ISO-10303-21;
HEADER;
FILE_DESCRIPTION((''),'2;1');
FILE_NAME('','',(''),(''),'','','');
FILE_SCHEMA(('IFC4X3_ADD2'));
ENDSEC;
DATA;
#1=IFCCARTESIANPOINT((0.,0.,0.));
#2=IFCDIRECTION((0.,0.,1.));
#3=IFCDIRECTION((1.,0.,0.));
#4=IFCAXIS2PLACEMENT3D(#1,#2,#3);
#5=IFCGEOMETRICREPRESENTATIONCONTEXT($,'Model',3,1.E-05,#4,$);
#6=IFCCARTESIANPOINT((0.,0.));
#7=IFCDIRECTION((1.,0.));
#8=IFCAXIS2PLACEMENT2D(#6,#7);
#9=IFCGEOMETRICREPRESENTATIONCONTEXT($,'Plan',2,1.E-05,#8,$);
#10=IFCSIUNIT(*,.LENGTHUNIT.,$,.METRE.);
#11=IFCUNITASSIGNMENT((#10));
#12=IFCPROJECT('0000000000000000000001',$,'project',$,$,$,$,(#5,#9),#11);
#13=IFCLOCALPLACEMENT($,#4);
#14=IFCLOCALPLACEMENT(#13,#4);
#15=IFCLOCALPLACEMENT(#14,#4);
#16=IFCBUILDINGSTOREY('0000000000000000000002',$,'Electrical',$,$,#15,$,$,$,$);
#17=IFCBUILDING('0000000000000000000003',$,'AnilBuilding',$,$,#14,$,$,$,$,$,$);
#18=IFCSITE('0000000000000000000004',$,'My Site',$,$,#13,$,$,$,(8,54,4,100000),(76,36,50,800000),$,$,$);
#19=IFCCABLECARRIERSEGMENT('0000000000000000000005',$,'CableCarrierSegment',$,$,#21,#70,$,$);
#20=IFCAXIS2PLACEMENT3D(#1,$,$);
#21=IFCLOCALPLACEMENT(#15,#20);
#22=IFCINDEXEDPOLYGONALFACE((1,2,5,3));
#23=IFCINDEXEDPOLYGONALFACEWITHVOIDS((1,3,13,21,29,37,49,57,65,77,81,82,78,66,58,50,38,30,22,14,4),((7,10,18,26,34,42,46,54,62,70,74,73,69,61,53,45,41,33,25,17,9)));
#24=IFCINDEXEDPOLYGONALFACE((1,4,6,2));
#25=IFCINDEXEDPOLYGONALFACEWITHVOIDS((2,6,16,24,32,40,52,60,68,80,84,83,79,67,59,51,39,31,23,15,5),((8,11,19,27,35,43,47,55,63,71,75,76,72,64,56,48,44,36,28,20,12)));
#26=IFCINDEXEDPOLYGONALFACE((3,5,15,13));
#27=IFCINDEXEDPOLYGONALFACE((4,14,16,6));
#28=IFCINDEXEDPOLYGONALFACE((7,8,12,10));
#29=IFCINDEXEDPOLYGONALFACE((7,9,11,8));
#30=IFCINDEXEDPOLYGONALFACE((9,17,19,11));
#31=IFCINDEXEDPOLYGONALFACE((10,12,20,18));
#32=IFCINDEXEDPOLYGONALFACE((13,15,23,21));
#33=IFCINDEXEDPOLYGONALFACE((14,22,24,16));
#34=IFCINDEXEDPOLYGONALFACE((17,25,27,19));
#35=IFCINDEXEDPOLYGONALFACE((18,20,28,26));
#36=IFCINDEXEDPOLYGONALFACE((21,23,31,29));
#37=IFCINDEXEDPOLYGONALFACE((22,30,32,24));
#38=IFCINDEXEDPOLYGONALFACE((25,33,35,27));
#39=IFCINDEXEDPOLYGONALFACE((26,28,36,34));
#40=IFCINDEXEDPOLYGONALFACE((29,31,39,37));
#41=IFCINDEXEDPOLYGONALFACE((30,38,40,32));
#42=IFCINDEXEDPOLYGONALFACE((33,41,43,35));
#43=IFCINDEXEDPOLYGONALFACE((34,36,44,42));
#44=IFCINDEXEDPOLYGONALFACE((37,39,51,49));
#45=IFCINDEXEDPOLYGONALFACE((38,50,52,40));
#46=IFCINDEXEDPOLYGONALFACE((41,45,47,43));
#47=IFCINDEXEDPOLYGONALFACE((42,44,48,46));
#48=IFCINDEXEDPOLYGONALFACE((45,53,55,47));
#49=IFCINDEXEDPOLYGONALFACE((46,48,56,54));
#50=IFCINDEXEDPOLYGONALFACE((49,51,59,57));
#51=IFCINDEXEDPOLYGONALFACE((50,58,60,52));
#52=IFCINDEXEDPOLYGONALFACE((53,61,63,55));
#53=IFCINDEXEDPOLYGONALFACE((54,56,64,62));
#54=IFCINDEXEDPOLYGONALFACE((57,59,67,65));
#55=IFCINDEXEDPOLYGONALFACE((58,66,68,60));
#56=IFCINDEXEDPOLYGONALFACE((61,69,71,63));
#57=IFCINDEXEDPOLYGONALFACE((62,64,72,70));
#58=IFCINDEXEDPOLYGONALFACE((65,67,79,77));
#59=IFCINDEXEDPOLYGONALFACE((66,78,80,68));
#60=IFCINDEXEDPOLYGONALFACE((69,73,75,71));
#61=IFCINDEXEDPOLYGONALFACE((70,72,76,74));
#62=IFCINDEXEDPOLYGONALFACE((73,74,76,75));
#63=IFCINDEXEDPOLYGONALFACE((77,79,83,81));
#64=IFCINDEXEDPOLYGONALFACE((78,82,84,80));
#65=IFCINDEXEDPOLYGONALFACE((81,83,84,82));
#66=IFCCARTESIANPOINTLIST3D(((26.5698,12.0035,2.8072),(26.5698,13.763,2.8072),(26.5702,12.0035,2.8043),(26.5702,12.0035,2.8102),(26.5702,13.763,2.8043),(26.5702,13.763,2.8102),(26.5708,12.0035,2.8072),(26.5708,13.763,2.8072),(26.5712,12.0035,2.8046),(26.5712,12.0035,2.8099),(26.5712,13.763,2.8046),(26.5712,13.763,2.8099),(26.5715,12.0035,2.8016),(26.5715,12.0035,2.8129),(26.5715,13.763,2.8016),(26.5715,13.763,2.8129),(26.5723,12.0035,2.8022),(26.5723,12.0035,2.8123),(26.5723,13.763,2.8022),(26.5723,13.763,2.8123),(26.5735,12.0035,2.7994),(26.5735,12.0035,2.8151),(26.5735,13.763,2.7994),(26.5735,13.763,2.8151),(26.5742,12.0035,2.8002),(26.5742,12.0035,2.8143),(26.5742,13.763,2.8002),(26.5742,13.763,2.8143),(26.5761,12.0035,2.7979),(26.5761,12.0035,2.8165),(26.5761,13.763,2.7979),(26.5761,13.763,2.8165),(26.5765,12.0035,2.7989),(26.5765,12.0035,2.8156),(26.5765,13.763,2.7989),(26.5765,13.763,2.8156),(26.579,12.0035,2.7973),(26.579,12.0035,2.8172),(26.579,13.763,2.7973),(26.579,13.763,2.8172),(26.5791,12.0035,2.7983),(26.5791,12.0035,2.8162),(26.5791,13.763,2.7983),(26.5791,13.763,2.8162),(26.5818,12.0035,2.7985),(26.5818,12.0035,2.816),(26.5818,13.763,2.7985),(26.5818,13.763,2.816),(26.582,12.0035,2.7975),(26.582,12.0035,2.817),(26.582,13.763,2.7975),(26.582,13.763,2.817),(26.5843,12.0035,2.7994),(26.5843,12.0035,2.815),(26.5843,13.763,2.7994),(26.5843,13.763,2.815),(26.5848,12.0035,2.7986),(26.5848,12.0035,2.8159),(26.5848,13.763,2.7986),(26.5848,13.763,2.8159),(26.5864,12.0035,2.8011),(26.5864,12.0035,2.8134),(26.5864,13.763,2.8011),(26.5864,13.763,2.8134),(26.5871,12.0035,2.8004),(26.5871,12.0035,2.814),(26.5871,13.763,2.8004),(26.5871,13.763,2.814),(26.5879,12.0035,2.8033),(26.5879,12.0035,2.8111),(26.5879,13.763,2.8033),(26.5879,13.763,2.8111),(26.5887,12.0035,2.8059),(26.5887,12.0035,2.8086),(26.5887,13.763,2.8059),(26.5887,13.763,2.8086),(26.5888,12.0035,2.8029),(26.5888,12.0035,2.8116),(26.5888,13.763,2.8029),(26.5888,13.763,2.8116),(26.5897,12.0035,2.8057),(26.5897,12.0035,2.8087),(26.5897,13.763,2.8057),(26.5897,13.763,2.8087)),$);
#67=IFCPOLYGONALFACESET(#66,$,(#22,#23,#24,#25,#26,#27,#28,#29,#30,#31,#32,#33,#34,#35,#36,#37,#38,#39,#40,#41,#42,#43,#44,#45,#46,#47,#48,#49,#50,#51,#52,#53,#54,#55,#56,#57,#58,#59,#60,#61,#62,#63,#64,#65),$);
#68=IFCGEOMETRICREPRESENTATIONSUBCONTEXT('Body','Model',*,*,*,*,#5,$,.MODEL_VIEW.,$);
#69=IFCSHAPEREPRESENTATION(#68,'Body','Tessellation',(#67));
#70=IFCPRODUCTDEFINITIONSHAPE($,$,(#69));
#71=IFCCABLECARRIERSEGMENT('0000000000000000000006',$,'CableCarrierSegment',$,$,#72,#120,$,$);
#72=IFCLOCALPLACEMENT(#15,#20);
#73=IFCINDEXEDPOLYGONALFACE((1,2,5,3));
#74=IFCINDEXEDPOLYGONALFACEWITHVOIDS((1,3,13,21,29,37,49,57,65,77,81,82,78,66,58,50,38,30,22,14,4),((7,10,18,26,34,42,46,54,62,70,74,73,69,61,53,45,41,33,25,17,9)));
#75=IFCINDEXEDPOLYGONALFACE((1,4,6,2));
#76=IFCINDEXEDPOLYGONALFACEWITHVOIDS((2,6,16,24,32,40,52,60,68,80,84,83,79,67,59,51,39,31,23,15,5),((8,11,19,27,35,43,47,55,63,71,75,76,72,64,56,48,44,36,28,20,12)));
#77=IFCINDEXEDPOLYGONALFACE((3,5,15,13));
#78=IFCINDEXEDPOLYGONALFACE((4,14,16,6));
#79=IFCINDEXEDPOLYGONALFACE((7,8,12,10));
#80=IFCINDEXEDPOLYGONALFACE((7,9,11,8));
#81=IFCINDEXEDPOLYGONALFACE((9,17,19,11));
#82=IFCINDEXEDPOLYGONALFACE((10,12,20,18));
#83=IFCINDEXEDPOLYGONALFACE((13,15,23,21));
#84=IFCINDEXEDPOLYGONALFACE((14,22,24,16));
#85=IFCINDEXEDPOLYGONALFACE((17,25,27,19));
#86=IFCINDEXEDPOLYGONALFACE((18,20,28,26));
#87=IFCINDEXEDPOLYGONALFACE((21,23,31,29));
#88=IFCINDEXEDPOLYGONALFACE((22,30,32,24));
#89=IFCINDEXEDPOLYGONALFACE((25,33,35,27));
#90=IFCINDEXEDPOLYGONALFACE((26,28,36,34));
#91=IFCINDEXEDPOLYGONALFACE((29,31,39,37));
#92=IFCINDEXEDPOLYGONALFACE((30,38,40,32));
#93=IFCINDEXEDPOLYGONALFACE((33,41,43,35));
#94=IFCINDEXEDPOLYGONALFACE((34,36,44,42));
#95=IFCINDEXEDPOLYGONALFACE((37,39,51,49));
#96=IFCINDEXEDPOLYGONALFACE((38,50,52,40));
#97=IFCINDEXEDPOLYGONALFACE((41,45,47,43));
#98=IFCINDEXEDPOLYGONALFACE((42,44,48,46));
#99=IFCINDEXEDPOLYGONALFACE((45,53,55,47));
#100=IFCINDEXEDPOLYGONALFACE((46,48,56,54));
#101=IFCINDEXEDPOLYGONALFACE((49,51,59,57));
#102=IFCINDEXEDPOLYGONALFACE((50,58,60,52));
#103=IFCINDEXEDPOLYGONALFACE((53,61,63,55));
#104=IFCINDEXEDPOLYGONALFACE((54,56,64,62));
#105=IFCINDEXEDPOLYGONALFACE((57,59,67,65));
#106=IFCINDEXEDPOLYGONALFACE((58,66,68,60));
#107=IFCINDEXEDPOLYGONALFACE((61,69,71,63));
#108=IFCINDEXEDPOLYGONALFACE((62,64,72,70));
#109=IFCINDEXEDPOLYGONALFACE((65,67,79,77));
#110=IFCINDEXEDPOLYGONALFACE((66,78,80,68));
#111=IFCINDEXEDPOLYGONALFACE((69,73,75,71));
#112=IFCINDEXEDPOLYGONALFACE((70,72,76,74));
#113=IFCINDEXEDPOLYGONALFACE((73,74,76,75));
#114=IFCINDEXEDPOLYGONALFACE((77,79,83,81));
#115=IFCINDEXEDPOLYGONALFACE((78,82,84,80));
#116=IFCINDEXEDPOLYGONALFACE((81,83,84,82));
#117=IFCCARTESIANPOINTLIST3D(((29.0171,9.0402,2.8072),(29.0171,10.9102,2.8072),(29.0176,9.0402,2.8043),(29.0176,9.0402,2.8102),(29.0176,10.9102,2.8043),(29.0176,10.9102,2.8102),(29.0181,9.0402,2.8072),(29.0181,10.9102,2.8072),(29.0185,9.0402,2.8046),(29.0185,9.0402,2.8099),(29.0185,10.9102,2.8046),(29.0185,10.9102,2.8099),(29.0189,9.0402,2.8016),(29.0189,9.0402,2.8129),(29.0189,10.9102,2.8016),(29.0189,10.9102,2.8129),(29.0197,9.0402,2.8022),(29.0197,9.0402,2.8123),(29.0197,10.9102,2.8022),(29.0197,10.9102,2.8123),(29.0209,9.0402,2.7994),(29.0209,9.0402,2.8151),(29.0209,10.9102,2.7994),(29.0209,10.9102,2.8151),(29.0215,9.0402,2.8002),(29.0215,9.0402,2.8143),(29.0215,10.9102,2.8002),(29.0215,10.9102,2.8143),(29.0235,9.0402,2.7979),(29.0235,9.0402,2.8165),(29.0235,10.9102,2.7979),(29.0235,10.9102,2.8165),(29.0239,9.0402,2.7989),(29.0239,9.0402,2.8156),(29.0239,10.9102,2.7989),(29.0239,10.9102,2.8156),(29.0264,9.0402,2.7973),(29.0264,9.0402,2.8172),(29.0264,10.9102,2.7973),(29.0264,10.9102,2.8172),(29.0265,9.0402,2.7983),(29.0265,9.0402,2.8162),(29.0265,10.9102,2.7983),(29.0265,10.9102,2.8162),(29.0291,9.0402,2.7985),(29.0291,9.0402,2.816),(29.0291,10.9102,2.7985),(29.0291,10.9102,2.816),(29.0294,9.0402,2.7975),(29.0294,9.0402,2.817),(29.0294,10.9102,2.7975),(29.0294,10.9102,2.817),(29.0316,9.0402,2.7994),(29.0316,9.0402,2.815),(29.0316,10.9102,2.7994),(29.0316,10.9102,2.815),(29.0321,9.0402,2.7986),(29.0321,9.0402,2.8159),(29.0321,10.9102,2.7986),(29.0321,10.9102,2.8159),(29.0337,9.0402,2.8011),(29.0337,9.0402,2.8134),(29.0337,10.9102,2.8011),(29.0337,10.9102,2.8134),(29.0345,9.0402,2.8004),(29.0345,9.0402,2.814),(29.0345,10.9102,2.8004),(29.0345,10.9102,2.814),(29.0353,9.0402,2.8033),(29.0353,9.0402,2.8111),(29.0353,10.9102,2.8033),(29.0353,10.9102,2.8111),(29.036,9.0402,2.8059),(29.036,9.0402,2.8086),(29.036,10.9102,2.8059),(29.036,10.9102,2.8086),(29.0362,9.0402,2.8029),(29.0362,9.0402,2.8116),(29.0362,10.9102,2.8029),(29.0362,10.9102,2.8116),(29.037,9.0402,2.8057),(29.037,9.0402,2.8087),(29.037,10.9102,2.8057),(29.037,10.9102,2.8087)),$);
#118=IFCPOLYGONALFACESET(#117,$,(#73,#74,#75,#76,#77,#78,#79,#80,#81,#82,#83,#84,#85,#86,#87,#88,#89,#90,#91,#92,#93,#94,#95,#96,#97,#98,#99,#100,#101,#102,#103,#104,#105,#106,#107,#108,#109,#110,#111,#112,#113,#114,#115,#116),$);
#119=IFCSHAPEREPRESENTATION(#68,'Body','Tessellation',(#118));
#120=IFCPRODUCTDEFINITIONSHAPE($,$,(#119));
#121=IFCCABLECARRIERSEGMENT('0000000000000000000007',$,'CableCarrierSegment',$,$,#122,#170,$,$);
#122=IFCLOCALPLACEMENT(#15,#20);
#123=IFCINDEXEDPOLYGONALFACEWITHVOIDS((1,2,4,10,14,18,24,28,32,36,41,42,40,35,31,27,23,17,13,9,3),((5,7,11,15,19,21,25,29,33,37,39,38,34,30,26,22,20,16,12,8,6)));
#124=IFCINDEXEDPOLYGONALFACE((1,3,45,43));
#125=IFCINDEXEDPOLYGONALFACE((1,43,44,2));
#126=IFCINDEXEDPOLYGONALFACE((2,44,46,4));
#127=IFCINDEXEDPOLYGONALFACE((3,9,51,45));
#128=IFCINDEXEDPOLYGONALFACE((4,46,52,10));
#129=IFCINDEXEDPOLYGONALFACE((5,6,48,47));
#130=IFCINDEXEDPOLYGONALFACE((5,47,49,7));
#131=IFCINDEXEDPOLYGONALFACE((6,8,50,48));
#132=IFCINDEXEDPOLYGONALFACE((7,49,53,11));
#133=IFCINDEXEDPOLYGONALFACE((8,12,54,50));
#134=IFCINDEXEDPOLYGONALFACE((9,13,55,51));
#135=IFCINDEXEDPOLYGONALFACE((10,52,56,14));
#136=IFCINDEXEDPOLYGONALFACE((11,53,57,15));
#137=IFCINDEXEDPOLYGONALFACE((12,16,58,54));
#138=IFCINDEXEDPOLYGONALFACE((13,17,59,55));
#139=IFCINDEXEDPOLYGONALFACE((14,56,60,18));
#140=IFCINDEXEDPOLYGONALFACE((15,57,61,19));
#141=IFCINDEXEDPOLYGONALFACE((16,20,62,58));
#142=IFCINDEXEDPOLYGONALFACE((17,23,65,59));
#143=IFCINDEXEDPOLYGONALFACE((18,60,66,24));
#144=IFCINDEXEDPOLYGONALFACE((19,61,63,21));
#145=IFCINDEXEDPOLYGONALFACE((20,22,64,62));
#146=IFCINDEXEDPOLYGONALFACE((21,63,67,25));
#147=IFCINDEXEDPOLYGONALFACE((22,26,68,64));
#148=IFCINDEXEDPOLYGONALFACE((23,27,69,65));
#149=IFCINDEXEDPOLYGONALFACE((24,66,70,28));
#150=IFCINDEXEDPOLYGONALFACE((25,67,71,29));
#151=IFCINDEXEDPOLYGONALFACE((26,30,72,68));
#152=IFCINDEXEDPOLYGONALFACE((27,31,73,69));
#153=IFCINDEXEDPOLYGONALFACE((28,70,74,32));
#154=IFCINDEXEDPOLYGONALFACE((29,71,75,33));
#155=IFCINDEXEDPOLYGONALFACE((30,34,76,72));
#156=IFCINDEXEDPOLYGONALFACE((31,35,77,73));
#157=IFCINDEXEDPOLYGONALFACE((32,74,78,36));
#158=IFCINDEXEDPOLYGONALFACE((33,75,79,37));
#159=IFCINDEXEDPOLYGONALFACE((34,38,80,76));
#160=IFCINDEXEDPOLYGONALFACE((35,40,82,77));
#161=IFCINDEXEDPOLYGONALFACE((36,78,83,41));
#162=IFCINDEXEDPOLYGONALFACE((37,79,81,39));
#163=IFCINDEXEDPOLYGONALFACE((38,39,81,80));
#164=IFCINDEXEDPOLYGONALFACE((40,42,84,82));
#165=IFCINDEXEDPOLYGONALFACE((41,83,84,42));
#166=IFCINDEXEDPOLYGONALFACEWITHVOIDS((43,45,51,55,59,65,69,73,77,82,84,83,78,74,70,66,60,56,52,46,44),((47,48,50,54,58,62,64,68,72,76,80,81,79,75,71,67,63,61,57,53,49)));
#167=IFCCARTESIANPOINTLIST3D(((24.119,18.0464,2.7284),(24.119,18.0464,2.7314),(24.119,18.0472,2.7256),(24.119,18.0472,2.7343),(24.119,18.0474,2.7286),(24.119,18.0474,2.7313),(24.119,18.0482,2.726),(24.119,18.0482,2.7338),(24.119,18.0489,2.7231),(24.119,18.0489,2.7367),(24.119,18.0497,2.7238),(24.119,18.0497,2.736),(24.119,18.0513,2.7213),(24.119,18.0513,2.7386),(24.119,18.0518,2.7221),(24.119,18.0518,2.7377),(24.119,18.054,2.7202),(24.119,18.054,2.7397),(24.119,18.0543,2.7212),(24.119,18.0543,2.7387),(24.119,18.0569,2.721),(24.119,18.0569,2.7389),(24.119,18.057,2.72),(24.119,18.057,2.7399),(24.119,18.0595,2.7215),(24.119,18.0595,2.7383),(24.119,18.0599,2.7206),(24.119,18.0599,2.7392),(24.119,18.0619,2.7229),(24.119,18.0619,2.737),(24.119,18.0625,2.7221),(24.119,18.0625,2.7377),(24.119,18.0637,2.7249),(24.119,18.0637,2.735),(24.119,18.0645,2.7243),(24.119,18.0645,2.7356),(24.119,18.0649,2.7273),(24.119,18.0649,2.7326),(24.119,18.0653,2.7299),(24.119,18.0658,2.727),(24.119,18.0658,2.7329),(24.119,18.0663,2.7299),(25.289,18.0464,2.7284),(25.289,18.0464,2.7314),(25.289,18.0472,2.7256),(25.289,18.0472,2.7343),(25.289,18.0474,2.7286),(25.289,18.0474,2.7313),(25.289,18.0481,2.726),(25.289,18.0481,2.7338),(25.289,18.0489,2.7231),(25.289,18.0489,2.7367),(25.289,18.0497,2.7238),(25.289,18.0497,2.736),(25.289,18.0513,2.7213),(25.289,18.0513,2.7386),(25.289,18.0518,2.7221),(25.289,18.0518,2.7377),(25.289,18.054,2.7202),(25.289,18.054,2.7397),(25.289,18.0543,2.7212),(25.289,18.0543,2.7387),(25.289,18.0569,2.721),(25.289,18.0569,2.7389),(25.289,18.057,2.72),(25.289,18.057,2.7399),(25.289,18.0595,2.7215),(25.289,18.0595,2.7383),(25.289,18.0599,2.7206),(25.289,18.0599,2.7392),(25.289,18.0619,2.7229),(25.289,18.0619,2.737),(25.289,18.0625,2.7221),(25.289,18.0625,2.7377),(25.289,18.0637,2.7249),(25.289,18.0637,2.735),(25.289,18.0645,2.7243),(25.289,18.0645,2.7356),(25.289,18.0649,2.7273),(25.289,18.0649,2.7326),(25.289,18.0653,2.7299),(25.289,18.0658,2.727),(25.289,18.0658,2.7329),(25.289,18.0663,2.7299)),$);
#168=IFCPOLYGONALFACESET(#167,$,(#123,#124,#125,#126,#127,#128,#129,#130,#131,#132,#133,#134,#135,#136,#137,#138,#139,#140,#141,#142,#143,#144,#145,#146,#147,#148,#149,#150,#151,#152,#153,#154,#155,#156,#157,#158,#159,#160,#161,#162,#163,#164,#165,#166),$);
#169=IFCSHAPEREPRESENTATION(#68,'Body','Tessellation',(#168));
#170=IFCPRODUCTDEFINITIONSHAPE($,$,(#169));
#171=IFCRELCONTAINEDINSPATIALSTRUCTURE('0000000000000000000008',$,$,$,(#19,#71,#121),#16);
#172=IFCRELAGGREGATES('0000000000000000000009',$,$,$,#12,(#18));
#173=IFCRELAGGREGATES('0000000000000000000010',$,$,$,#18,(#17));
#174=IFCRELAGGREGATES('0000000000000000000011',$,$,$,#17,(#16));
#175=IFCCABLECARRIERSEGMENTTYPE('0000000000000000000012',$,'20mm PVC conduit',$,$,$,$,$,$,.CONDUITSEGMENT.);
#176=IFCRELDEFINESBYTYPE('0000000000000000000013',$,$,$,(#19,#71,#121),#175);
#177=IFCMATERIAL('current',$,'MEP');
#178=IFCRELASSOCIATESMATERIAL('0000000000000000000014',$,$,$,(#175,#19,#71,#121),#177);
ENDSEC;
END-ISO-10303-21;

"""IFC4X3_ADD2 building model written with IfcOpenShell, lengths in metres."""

from ifc_helpers import new_model, si_unit, frame, origin_with_axes, origin_2d_with_axis, place, context, subcontext, project, spatial, hollow_circle, extrude, material, material_profile, profile_set, profile_usage, type_object, element, save


model = new_model("IFC4X3_ADD2")

# Units and contexts
model_context = context("Model", 3, precision=1e-05, world=origin_with_axes())
plan_context = context("Plan", 2, precision=1e-05, world=origin_2d_with_axis())
body_context = subcontext(model_context, "Body", "Model", "MODEL_VIEW")
ifc_project = project(units=[si_unit("LENGTHUNIT", "METRE")], contexts=[model_context, plan_context])

# Site, building, storey
site_placement = place(None, origin_with_axes())
site = spatial("IfcSite", under=ifc_project, at=site_placement, Name="My Site", RefLatitude=(8, 54, 4, 100000), RefLongitude=(76, 36, 50, 800000))
building_placement = place(site_placement, origin_with_axes())
building = spatial("IfcBuilding", under=site, at=building_placement, Name="AnilBuilding")
storey_placement = place(building_placement, origin_with_axes())
storey = spatial("IfcBuildingStorey", under=building, at=storey_placement, Name="Electrical")

# Cable carrier segments
ifc_material = material(Name="current", Category="MEP")
ifc_material_profile_1 = material_profile(ifc_material, hollow_circle(Radius=0.01, WallThickness=0.001))
ifc_profile_set_1 = profile_set([ifc_material_profile_1], Name="current")
ifc_material_profile_2 = material_profile(ifc_material, hollow_circle(Radius=0.01, WallThickness=0.001))
ifc_profile_set_2 = profile_set([ifc_material_profile_2], Name="current")
cable_carrier_segment_type = type_object("IfcCableCarrierSegmentType", Name="20mm PVC conduit", PredefinedType="CONDUITSEGMENT", material=ifc_profile_set_2)
ifc_profile_usage_1 = profile_usage(ifc_profile_set_1, cardinal=5)
cable_carrier_segment_1_placement = place(storey_placement, frame((26.5798, 12.0035, 2.8072), z_axis=(0.0, 1.0, 0.0), x_axis=(-1.0, 0.0, 0.0)))
element("IfcCableCarrierSegment", 1, at=cable_carrier_segment_1_placement, inside=storey, type_object=cable_carrier_segment_type, material=ifc_profile_usage_1, Name="CableCarrierSegment", context=body_context, shape_type="SweptSolid", body=[
    extrude(hollow_circle(Radius=0.01, WallThickness=0.001), origin_with_axes(), (0.0, 0.0, 1.0), 1.7594),
])
ifc_profile_usage_2 = profile_usage(ifc_profile_set_1, cardinal=5)
cable_carrier_segment_2_placement = place(storey_placement, frame((29.0271, 9.0402, 2.8072), z_axis=(0.0, 1.0, 0.0), x_axis=(-1.0, 0.0, 0.0)))
element("IfcCableCarrierSegment", 2, at=cable_carrier_segment_2_placement, inside=storey, type_object=cable_carrier_segment_type, material=ifc_profile_usage_2, Name="CableCarrierSegment", context=body_context, shape_type="SweptSolid", body=[
    extrude(hollow_circle(Radius=0.01, WallThickness=0.001), origin_with_axes(), (0.0, 0.0, 1.0), 1.87),
])
ifc_profile_usage_3 = profile_usage(ifc_profile_set_1, cardinal=5)
cable_carrier_segment_3_placement = place(storey_placement, frame((24.119, 18.0563, 2.7299), z_axis=(1.0, -0.000001, 0.0), x_axis=(0.000001, 1.0, 0.0)))
element("IfcCableCarrierSegment", 3, at=cable_carrier_segment_3_placement, inside=storey, type_object=cable_carrier_segment_type, material=ifc_profile_usage_3, Name="CableCarrierSegment", context=body_context, shape_type="SweptSolid", body=[
    extrude(hollow_circle(Radius=0.01, WallThickness=0.001), origin_with_axes(), (0.0, 0.0, 1.0), 1.17),
])

save(model, "model.ifc")
